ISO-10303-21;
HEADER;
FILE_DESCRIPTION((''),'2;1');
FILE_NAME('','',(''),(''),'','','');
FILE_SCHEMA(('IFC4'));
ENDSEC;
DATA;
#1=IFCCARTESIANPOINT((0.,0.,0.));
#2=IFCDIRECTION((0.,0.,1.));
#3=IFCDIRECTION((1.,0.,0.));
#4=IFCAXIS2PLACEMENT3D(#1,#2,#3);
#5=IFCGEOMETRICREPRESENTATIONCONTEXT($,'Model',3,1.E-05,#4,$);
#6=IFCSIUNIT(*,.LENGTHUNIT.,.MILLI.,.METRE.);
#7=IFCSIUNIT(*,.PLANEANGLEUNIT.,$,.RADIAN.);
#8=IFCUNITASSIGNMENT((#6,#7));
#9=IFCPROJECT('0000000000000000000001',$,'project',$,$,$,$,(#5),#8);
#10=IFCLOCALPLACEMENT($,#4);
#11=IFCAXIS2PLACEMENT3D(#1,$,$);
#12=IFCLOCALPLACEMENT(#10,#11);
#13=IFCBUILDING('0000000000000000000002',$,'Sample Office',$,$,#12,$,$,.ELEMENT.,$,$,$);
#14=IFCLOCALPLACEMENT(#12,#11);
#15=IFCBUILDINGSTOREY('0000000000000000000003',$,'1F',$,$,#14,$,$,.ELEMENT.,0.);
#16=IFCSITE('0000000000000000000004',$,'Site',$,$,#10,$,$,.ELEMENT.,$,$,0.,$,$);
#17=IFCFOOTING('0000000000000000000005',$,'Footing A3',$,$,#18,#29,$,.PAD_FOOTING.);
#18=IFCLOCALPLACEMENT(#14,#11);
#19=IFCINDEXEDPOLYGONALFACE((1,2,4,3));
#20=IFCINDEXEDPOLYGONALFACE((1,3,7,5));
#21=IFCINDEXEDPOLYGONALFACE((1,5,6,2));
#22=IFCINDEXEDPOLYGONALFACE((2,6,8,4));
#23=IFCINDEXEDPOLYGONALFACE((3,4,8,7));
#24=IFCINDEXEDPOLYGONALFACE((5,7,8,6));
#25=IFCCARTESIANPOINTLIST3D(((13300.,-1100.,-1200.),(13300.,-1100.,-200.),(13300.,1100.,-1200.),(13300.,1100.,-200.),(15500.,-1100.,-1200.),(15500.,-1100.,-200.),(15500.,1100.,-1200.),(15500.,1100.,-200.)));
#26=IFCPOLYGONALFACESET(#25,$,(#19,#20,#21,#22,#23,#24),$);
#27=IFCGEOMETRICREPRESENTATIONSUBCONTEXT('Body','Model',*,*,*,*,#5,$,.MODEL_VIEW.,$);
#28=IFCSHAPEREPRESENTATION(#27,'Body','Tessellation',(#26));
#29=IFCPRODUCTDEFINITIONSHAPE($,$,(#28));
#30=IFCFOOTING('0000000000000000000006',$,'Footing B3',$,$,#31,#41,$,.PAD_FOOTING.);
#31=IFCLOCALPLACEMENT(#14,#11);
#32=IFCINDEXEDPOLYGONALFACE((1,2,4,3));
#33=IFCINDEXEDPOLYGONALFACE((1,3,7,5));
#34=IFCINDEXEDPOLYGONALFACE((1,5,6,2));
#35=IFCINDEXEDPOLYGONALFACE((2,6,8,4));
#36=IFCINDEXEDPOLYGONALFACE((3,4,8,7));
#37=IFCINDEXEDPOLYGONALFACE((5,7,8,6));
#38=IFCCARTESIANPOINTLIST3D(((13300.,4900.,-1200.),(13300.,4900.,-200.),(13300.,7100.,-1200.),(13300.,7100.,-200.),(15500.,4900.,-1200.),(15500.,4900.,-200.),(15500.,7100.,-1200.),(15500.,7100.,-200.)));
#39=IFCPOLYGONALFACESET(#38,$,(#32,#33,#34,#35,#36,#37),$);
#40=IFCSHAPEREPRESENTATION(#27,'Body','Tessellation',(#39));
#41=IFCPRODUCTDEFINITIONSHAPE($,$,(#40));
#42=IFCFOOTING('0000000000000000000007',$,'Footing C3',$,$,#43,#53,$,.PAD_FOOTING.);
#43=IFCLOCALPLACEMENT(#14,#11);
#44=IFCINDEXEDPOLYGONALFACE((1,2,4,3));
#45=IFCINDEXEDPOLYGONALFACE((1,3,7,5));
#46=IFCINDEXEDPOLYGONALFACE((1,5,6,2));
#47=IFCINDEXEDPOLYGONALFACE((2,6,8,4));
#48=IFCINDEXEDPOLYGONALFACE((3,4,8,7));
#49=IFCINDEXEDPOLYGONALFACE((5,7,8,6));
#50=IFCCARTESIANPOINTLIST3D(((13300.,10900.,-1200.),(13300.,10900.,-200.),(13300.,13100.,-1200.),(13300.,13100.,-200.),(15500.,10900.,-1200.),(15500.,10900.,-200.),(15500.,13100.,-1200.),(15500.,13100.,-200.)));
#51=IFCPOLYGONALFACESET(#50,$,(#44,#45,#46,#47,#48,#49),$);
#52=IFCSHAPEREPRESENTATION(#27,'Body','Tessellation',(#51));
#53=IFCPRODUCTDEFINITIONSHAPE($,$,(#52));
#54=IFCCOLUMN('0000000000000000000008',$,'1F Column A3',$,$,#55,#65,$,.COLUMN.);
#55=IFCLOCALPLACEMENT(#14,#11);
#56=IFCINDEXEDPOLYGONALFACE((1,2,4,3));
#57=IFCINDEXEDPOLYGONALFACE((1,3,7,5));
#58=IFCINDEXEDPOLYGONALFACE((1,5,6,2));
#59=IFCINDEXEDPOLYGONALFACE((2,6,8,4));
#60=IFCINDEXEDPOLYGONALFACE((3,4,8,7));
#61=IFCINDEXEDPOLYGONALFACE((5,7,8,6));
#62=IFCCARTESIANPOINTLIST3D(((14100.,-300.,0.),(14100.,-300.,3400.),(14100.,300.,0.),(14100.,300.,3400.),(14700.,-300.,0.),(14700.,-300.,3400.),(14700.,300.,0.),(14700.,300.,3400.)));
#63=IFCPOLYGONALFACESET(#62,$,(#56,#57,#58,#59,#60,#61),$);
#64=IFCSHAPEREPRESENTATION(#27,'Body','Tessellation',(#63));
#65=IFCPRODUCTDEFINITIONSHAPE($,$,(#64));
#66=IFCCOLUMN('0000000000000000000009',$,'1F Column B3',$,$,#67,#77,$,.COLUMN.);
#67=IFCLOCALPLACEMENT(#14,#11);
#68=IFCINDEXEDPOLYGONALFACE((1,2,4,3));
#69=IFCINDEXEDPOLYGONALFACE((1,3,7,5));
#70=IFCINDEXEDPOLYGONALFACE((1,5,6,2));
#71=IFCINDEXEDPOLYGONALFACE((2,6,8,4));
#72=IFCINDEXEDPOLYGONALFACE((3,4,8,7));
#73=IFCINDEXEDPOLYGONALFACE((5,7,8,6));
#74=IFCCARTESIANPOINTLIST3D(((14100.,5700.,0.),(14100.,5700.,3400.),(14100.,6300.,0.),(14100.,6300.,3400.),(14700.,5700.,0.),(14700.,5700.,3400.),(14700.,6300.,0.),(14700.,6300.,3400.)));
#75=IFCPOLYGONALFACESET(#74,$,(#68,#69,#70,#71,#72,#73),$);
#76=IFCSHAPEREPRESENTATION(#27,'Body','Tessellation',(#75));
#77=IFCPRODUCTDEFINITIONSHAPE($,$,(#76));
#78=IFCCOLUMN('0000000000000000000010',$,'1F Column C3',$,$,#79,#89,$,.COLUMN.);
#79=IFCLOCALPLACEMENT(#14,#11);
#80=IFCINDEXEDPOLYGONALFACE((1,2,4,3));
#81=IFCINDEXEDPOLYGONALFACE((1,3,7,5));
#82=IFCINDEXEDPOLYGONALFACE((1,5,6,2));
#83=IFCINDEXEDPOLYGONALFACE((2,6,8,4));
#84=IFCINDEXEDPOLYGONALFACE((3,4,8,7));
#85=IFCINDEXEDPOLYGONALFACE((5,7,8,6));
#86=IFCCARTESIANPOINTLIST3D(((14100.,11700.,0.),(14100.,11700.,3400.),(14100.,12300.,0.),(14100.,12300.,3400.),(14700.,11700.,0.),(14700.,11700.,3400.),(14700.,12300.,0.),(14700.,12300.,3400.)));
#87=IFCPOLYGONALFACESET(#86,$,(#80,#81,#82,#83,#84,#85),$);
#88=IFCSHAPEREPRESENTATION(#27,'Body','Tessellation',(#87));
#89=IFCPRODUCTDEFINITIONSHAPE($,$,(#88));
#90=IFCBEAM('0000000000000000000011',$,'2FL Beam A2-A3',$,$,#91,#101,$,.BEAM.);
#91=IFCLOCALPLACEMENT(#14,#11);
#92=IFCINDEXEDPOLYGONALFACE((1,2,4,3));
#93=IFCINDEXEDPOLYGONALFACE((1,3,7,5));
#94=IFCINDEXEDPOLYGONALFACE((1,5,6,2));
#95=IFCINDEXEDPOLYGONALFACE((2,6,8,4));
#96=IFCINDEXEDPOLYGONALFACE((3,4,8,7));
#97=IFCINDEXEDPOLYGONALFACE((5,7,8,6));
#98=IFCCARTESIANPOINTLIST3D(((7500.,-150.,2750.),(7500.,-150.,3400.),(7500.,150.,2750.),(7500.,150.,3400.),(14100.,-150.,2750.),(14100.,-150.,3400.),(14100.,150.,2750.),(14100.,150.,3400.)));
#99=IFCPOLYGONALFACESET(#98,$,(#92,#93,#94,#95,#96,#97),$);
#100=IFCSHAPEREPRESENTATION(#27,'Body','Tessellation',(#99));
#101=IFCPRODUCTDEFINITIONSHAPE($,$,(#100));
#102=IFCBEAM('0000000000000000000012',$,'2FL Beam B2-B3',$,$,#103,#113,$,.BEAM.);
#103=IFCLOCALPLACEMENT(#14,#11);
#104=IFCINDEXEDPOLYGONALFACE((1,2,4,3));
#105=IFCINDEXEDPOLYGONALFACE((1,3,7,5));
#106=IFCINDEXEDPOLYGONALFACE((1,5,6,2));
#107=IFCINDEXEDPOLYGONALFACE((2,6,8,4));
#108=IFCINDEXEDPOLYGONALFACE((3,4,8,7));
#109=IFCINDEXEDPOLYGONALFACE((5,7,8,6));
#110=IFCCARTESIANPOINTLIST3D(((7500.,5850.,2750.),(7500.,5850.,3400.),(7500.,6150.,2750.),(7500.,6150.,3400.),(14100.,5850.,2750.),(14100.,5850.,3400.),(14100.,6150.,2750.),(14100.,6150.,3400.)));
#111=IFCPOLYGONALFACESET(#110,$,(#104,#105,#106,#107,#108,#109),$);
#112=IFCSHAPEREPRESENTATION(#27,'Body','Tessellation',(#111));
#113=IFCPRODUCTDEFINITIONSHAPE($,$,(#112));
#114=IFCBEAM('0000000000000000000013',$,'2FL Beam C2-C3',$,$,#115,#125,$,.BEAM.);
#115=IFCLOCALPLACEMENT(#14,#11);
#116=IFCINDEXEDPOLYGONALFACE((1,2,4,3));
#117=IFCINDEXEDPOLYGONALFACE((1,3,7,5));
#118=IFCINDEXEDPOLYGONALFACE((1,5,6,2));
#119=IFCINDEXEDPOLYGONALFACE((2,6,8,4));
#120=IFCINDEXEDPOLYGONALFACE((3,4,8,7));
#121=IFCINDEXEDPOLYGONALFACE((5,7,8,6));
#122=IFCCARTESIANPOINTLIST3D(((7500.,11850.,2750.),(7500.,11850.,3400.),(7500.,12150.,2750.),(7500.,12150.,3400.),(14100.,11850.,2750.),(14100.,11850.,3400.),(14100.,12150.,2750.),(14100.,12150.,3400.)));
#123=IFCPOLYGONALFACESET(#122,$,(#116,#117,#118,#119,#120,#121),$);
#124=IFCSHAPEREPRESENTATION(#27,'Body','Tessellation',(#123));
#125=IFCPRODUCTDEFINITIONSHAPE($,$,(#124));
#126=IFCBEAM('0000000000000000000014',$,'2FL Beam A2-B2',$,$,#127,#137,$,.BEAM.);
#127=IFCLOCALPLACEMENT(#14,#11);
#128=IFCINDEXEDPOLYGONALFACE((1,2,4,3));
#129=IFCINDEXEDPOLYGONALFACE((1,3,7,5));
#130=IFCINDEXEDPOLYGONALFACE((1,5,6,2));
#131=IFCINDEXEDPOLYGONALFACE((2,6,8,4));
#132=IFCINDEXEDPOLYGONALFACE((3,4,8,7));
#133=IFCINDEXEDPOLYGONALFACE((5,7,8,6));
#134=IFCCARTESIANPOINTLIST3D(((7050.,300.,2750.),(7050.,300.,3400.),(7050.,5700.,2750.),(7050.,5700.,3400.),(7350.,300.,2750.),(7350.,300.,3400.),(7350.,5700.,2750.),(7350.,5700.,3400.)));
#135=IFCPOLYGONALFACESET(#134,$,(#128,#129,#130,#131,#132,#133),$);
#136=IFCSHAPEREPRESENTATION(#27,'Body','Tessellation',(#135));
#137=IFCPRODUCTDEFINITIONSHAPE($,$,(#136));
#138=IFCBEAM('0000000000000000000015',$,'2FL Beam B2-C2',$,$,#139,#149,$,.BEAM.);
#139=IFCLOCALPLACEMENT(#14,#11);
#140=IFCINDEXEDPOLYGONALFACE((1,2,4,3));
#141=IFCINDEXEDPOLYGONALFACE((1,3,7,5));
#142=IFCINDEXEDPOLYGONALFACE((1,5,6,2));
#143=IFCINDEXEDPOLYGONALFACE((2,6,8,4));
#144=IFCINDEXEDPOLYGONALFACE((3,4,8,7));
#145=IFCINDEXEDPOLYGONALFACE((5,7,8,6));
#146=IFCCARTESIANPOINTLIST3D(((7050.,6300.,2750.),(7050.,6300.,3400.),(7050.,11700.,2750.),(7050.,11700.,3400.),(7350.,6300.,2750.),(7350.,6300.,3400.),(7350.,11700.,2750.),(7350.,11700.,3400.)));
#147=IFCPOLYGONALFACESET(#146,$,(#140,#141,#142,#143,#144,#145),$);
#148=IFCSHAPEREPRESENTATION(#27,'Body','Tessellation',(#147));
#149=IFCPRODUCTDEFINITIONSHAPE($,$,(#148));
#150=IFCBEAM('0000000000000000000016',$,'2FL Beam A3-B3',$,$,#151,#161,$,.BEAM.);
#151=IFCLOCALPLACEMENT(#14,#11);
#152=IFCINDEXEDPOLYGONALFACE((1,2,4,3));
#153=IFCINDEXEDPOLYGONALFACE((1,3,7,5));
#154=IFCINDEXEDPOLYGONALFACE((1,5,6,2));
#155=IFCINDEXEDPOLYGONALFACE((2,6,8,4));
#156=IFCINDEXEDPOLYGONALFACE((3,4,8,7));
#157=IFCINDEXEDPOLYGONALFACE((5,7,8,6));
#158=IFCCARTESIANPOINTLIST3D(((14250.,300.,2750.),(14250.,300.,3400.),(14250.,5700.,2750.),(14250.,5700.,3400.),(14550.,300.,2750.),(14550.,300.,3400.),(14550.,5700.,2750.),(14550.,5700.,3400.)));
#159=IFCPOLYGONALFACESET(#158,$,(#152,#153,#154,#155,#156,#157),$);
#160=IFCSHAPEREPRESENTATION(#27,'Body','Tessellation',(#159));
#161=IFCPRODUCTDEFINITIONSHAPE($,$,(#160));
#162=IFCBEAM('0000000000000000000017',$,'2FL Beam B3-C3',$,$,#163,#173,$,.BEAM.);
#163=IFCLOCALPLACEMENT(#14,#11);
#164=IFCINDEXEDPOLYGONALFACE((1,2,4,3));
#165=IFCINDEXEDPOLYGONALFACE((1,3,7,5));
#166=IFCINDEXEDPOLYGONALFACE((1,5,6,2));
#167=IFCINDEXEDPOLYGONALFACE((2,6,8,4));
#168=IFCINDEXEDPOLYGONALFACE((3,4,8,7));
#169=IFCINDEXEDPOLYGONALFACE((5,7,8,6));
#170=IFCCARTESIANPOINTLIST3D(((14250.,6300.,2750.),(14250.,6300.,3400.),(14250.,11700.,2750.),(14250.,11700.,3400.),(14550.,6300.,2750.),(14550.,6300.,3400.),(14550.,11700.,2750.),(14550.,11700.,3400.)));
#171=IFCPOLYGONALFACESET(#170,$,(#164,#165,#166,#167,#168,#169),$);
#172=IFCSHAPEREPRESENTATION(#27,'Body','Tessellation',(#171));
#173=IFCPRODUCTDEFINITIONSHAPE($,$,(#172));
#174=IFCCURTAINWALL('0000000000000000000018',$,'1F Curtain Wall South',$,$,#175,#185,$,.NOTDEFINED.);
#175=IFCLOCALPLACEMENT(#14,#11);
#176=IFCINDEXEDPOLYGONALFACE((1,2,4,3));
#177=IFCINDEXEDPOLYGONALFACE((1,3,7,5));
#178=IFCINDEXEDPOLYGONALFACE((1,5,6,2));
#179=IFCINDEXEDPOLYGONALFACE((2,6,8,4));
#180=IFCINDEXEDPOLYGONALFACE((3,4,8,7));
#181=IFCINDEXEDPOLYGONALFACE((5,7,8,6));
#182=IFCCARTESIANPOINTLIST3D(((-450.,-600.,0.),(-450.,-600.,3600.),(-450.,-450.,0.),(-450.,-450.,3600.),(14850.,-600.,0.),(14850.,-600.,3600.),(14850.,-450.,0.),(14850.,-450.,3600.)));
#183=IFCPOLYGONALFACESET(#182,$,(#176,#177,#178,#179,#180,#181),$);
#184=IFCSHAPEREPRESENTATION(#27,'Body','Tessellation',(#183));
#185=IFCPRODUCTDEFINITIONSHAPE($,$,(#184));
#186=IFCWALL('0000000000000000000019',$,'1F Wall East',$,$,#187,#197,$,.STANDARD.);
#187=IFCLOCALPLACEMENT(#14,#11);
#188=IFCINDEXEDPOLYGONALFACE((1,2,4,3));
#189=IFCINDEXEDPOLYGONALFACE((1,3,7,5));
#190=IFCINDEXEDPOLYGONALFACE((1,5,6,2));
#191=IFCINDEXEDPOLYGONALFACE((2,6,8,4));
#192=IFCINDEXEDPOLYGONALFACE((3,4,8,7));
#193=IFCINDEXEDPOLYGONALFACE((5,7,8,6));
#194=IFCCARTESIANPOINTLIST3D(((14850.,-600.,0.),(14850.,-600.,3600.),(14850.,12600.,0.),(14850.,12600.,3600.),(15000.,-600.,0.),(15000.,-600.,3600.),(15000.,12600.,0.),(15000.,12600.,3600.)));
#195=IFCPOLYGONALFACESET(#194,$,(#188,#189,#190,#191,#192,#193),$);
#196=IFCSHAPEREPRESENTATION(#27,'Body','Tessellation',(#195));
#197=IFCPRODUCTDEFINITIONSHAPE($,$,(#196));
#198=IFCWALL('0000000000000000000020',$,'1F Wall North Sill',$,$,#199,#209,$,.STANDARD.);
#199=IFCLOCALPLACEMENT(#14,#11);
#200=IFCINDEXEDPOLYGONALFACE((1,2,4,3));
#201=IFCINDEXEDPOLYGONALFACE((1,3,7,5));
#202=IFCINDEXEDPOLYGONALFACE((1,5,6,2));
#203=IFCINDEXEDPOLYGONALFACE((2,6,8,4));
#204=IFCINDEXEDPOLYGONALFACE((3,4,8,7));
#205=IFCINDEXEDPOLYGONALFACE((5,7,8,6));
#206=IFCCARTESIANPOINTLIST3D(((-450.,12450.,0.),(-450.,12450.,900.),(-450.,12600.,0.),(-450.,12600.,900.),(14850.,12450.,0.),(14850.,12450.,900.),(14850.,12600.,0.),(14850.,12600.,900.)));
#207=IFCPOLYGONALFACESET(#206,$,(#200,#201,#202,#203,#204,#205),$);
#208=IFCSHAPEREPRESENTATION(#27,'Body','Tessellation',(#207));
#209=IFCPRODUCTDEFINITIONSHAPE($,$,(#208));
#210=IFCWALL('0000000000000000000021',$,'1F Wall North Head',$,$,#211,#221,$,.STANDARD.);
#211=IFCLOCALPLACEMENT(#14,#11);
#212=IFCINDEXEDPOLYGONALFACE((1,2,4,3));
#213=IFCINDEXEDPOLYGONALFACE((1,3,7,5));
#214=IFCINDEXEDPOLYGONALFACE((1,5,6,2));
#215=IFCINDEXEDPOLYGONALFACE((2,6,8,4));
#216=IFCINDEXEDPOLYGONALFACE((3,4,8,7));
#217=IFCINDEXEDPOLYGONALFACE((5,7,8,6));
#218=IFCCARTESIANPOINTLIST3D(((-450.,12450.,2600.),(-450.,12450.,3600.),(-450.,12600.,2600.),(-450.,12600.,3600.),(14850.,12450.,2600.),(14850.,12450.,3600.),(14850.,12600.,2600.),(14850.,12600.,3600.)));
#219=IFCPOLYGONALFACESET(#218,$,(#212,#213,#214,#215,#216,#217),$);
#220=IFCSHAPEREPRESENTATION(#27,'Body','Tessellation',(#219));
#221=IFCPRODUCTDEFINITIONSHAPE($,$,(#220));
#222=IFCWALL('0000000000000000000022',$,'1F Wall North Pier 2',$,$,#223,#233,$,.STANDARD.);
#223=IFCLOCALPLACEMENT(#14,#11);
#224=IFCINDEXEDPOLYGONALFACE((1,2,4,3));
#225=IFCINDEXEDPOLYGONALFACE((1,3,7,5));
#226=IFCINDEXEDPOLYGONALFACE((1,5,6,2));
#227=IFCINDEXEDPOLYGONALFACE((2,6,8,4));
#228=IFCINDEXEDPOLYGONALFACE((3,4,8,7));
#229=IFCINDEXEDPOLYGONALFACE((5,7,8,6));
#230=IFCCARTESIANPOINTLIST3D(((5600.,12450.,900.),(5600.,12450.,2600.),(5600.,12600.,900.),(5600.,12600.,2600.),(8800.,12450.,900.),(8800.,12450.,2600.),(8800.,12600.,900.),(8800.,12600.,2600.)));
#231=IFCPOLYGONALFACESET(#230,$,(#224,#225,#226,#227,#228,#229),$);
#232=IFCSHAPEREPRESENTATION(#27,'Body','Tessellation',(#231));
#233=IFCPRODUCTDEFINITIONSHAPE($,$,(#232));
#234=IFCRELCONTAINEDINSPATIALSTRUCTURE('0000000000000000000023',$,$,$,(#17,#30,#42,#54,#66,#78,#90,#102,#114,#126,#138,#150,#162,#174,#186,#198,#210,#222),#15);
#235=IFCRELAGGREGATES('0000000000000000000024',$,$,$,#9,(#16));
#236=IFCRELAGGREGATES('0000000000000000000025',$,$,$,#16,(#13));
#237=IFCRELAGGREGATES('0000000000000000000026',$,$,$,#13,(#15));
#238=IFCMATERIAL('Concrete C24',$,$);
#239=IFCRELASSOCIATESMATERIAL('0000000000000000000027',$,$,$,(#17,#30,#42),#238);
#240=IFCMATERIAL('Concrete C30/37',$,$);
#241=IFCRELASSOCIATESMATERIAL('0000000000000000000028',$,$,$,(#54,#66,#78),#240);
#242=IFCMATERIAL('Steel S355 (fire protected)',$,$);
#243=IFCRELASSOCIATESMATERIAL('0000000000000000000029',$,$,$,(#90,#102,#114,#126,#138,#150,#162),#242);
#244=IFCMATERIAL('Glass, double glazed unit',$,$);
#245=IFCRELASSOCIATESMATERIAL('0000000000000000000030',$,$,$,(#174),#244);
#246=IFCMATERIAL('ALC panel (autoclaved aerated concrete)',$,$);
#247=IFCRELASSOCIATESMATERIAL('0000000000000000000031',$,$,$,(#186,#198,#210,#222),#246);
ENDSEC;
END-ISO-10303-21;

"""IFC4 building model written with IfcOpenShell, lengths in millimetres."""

from ifc_helpers import new_model, si_unit, frame, origin, origin_with_axes, origin_2d, place, context, subcontext, project, spatial, rectangle, extrude, material, element, save


model = new_model("IFC4")

# Units and contexts
model_context = context("Model", 3, precision=1e-05, world=origin_with_axes())
body_context = subcontext(model_context, "Body", "Model", "MODEL_VIEW")
ifc_project = project(units=[si_unit("LENGTHUNIT", "METRE", prefix="MILLI"), si_unit("PLANEANGLEUNIT", "RADIAN")], contexts=[model_context])

# Site, building, storey
site_placement = place(None, origin_with_axes())
site = spatial("IfcSite", under=ifc_project, at=site_placement, Name="Site", CompositionType="ELEMENT", RefElevation=0.0)
building_placement = place(site_placement, origin())
building = spatial("IfcBuilding", under=site, at=building_placement, Name="Sample Office", CompositionType="ELEMENT")
storey_placement = place(building_placement, origin())
storey = spatial("IfcBuildingStorey", under=building, at=storey_placement, Name="1F", CompositionType="ELEMENT", Elevation=0.0)

# Footings
ifc_material_1 = material(Name="Concrete C24")
for number, where, name in (
    (1, (14400.0, 0.0, -1200.0), "Footing A3"),
    (2, (14400.0, 6000.0, -1200.0), "Footing B3"),
    (3, (14400.0, 12000.0, -1200.0), "Footing C3"),
):
    element("IfcFooting", number, at=place(storey_placement, frame(where)), inside=storey, material=ifc_material_1, Name=name, PredefinedType="PAD_FOOTING", context=body_context, shape_type="SweptSolid", body=[
        extrude(rectangle(XDim=2200.0, YDim=2200.0, at=origin_2d()), origin(), (0.0, 0.0, 1.0), 1000.0),
    ])

# Columns
ifc_material_2 = material(Name="Concrete C30/37")
for number, where, name in (
    (4, (14400.0, 0.0, 0.0), "1F Column A3"),
    (5, (14400.0, 6000.0, 0.0), "1F Column B3"),
    (6, (14400.0, 12000.0, 0.0), "1F Column C3"),
):
    element("IfcColumn", number, at=place(storey_placement, frame(where)), inside=storey, material=ifc_material_2, Name=name, PredefinedType="COLUMN", context=body_context, shape_type="SweptSolid", body=[
        extrude(rectangle(XDim=600.0, YDim=600.0, at=origin_2d()), origin(), (0.0, 0.0, 1.0), 3400.0),
    ])

# Beams
ifc_material_3 = material(Name="Steel S355 (fire protected)")
for number, where, name in (
    (7, (10800.0, 0.0, 2750.0), "2FL Beam A2-A3"),
    (8, (10800.0, 6000.0, 2750.0), "2FL Beam B2-B3"),
    (9, (10800.0, 12000.0, 2750.0), "2FL Beam C2-C3"),
):
    element("IfcBeam", number, at=place(storey_placement, frame(where)), inside=storey, material=ifc_material_3, Name=name, PredefinedType="BEAM", context=body_context, shape_type="SweptSolid", body=[
        extrude(rectangle(XDim=6600.0, YDim=300.0, at=origin_2d()), origin(), (0.0, 0.0, 1.0), 650.0),
    ])
for number, where, name in (
    (10, (7200.0, 3000.0, 2750.0), "2FL Beam A2-B2"),
    (11, (7200.0, 9000.0, 2750.0), "2FL Beam B2-C2"),
    (12, (14400.0, 3000.0, 2750.0), "2FL Beam A3-B3"),
    (13, (14400.0, 9000.0, 2750.0), "2FL Beam B3-C3"),
):
    element("IfcBeam", number, at=place(storey_placement, frame(where)), inside=storey, material=ifc_material_3, Name=name, PredefinedType="BEAM", context=body_context, shape_type="SweptSolid", body=[
        extrude(rectangle(XDim=300.0, YDim=5400.0, at=origin_2d()), origin(), (0.0, 0.0, 1.0), 650.0),
    ])

# Curtain wall
ifc_material_4 = material(Name="Glass, double glazed unit")
curtain_wall_placement = place(storey_placement, frame((7200.0, -525.0, 0.0)))
element("IfcCurtainWall", 14, at=curtain_wall_placement, inside=storey, material=ifc_material_4, Name="1F Curtain Wall South", PredefinedType="NOTDEFINED", context=body_context, shape_type="SweptSolid", body=[
    extrude(rectangle(XDim=15300.0, YDim=150.0, at=origin_2d()), origin(), (0.0, 0.0, 1.0), 3600.0),
])

# Walls
ifc_material_5 = material(Name="ALC panel (autoclaved aerated concrete)")
wall_1_placement = place(storey_placement, frame((14925.0, 6000.0, 0.0)))
element("IfcWall", 15, at=wall_1_placement, inside=storey, material=ifc_material_5, Name="1F Wall East", PredefinedType="STANDARD", context=body_context, shape_type="SweptSolid", body=[
    extrude(rectangle(XDim=150.0, YDim=13200.0, at=origin_2d()), origin(), (0.0, 0.0, 1.0), 3600.0),
])
wall_2_placement = place(storey_placement, frame((7200.0, 12525.0, 0.0)))
element("IfcWall", 16, at=wall_2_placement, inside=storey, material=ifc_material_5, Name="1F Wall North Sill", PredefinedType="STANDARD", context=body_context, shape_type="SweptSolid", body=[
    extrude(rectangle(XDim=15300.0, YDim=150.0, at=origin_2d()), origin(), (0.0, 0.0, 1.0), 900.0),
])
wall_3_placement = place(storey_placement, frame((7200.0, 12525.0, 2600.0)))
element("IfcWall", 17, at=wall_3_placement, inside=storey, material=ifc_material_5, Name="1F Wall North Head", PredefinedType="STANDARD", context=body_context, shape_type="SweptSolid", body=[
    extrude(rectangle(XDim=15300.0, YDim=150.0, at=origin_2d()), origin(), (0.0, 0.0, 1.0), 1000.0),
])
wall_4_placement = place(storey_placement, frame((7200.0, 12525.0, 900.0)))
element("IfcWall", 18, at=wall_4_placement, inside=storey, material=ifc_material_5, Name="1F Wall North Pier 2", PredefinedType="STANDARD", context=body_context, shape_type="SweptSolid", body=[
    extrude(rectangle(XDim=3200.0, YDim=150.0, at=origin_2d()), origin(), (0.0, 0.0, 1.0), 1700.0),
])

save(model, "model.ifc")
